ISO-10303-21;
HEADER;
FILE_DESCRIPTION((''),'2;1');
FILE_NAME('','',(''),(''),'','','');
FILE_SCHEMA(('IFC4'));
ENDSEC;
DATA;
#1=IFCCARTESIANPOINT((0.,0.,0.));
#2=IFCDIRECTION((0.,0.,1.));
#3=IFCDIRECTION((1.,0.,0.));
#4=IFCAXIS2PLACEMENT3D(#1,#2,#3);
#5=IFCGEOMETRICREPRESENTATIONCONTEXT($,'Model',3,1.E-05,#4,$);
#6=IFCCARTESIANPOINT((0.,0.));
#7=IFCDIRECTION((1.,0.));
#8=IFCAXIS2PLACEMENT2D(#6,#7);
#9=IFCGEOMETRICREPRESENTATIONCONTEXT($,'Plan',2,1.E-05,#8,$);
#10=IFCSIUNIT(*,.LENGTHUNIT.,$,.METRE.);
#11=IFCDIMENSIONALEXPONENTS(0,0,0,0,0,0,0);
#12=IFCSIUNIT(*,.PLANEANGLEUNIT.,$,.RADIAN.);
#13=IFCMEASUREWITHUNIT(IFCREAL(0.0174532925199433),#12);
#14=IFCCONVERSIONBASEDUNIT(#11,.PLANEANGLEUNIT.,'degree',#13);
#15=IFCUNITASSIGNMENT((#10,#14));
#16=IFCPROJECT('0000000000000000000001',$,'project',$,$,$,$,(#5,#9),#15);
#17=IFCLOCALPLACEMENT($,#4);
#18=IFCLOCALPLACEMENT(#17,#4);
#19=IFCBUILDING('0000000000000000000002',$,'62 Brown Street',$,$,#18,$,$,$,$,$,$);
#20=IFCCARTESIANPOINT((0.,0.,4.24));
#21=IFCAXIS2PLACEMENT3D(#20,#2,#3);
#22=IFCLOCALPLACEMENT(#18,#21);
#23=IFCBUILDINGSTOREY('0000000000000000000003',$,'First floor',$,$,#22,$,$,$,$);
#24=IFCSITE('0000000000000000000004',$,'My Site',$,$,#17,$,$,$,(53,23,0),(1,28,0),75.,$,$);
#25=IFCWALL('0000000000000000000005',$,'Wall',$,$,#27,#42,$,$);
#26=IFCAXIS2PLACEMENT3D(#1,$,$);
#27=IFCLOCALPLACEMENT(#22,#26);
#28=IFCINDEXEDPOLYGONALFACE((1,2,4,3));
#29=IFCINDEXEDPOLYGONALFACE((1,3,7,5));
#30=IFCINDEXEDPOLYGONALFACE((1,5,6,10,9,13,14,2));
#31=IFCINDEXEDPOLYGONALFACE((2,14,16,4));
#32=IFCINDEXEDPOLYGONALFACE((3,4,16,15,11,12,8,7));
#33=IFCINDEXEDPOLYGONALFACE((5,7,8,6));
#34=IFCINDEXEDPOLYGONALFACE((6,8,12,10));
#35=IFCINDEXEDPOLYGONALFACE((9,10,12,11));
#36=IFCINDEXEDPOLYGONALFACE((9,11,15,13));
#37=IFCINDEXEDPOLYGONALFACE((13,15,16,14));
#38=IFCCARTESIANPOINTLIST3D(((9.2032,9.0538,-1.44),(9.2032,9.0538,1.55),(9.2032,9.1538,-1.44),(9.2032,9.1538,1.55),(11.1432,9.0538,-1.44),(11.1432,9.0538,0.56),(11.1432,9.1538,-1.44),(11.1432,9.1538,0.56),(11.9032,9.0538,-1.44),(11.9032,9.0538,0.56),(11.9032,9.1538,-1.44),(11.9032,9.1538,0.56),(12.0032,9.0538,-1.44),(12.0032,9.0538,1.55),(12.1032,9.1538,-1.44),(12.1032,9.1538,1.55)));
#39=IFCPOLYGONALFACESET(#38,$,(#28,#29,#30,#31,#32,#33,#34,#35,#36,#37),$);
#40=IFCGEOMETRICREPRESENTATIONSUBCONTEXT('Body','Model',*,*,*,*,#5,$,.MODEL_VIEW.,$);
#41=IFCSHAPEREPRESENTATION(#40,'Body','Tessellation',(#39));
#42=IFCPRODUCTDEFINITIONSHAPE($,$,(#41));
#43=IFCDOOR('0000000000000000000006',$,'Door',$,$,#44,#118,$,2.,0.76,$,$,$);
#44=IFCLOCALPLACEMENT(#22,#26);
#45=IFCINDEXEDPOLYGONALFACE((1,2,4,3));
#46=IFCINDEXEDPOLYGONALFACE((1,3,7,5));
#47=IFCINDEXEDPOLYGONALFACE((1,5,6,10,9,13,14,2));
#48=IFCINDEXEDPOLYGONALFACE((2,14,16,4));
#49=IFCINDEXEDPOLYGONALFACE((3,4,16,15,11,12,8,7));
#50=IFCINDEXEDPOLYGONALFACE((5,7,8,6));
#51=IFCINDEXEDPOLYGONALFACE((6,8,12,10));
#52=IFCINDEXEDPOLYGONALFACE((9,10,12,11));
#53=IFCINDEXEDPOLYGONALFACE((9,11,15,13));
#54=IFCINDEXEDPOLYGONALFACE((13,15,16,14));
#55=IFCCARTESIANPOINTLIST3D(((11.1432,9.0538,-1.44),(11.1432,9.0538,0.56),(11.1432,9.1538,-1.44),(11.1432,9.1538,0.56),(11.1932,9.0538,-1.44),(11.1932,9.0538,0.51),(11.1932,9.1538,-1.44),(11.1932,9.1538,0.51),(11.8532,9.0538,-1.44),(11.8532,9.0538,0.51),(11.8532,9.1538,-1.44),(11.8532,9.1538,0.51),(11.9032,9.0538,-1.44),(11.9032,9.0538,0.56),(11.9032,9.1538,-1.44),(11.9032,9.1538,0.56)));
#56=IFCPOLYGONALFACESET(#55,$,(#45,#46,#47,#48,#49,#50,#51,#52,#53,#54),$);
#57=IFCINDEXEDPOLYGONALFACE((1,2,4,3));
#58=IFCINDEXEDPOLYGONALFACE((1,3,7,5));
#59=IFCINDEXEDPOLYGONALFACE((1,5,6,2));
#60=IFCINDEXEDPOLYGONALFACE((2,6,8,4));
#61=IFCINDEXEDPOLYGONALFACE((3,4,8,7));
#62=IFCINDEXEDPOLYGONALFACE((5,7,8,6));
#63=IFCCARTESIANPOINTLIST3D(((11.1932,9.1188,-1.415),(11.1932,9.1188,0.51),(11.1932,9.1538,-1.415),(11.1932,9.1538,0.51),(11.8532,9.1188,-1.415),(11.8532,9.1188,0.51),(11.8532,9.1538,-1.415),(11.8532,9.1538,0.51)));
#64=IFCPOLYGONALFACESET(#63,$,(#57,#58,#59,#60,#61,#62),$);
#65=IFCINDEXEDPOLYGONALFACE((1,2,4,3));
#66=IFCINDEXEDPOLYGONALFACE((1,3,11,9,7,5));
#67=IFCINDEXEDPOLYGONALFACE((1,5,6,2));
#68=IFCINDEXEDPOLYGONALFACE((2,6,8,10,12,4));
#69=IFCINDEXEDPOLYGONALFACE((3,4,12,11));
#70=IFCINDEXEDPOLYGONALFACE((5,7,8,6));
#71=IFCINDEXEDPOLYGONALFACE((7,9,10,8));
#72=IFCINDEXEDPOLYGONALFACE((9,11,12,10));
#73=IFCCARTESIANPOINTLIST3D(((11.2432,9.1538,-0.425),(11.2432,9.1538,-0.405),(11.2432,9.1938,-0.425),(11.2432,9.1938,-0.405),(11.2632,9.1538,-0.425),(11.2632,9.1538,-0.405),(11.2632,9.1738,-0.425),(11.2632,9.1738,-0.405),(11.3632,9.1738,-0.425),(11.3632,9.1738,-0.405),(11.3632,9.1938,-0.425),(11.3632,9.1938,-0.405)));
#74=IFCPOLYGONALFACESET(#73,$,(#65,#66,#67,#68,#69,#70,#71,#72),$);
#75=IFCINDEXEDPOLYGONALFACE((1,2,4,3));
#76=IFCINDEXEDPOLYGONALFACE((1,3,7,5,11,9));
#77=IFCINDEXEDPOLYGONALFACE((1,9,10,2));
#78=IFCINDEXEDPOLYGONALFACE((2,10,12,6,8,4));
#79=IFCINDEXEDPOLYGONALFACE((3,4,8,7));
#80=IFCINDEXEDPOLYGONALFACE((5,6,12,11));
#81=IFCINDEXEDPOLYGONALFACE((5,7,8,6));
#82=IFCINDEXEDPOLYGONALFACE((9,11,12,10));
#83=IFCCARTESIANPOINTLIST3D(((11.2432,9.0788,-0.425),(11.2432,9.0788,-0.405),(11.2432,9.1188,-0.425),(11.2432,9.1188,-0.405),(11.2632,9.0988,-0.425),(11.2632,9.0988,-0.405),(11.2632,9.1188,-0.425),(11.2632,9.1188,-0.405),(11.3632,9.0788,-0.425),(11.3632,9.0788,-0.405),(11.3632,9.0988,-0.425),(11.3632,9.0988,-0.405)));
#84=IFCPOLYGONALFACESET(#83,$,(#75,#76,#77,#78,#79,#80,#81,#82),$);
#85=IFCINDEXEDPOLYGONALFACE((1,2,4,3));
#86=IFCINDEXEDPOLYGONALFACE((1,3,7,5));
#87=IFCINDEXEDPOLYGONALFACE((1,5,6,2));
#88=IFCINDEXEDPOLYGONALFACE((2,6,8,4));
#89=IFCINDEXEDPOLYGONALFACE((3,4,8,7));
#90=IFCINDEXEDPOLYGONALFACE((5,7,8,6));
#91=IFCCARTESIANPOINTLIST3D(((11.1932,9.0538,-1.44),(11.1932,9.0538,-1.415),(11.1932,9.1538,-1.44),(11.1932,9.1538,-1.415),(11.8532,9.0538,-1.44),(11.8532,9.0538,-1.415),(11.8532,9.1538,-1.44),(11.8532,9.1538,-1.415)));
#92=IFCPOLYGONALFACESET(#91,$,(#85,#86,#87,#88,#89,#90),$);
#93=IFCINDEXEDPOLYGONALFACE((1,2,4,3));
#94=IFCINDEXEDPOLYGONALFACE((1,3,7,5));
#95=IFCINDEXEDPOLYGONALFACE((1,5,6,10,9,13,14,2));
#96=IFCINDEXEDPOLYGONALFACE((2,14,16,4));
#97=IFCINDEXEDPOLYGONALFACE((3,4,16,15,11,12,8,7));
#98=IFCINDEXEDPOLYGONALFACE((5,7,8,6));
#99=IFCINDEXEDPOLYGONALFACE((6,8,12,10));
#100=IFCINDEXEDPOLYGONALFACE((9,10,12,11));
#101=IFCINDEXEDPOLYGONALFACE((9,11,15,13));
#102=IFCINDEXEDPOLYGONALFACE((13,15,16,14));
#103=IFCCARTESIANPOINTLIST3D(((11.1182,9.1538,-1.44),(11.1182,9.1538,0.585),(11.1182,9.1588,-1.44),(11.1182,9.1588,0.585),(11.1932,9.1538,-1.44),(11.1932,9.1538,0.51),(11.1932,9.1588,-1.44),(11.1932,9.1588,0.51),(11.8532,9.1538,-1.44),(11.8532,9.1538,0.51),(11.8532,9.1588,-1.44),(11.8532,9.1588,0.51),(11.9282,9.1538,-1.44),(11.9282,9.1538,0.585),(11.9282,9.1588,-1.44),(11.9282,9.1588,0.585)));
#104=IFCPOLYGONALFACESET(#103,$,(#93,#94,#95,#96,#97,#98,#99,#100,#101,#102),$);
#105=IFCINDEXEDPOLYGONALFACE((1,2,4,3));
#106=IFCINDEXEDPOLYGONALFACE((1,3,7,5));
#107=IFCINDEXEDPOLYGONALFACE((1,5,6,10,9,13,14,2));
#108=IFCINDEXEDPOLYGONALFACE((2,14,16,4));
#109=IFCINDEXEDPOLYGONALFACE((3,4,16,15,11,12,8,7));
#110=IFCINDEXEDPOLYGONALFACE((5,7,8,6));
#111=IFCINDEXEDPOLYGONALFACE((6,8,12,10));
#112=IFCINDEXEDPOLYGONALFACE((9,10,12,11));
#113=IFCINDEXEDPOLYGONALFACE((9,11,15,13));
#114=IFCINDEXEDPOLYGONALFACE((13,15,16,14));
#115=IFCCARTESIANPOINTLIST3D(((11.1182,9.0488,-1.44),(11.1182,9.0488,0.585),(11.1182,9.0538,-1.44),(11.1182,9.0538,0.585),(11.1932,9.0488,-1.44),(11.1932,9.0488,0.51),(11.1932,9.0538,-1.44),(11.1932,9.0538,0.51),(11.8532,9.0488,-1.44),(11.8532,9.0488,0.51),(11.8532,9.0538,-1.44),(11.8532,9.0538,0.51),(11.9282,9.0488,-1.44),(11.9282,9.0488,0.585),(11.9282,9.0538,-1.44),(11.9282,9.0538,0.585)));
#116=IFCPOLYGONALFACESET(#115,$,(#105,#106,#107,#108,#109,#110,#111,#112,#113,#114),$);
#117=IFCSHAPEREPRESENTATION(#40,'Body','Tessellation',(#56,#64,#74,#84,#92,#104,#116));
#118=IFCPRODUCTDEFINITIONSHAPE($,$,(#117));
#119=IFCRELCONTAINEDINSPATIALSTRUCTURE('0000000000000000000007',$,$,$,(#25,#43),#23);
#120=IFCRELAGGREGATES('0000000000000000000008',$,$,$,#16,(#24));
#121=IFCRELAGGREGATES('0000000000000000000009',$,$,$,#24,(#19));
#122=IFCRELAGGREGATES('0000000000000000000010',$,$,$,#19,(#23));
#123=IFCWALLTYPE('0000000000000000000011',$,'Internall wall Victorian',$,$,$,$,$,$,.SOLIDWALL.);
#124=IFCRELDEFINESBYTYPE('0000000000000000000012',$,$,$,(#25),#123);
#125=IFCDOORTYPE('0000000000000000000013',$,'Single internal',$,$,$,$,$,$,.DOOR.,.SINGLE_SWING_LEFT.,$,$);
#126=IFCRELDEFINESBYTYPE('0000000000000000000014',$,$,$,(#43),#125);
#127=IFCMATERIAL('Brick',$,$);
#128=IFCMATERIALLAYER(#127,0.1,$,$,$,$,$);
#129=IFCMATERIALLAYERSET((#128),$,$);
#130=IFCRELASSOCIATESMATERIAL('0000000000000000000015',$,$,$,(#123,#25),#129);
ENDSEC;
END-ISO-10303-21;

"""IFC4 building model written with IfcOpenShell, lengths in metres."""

from ifc_helpers import new_model, entity, si_unit, converted_unit, frame, origin_with_axes, origin_2d_with_axis, place, context, subcontext, project, spatial, line, indexed_curve, outline, extrude, clip, halfspace, shape, source, transform, mapped, material, layer, layer_set, layer_usage, type_object, type_shapes, element, fill, save


model = new_model("IFC4")

# Units and contexts
model_context = context("Model", 3, precision=1e-05, world=origin_with_axes())
plan_context = context("Plan", 2, precision=1e-05, world=origin_2d_with_axis())
body_context_1 = subcontext(model_context, "Body", "Model", "MODEL_VIEW")
body_context_2 = subcontext(plan_context, "Body", "Plan", "PLAN_VIEW")
ifc_project = project(units=[si_unit("LENGTHUNIT", "METRE"), converted_unit("PLANEANGLEUNIT", "degree", entity("IfcReal", 0.0174532925199433), si_unit("PLANEANGLEUNIT", "RADIAN"), dimensions=[0, 0, 0, 0, 0, 0, 0])], contexts=[model_context, plan_context])

# Site, building, storey
site_placement = place(None, origin_with_axes())
site = spatial("IfcSite", under=ifc_project, at=site_placement, Name="My Site", RefLatitude=(53, 23, 0), RefLongitude=(1, 28, 0), RefElevation=75.0)
building_placement = place(site_placement, origin_with_axes())
building = spatial("IfcBuilding", under=site, at=building_placement, Name="62 Brown Street")
storey_placement = place(building_placement, frame((0.0, 0.0, 4.24), z_axis=(0.0, 0.0, 1.0), x_axis=(1.0, 0.0, 0.0)))
storey = spatial("IfcBuildingStorey", under=building, at=storey_placement, Name="First floor")

# Shared definitions
ifc_material_1 = material(Name="Brick")
ifc_layer_1 = layer(ifc_material_1, 0.1)
ifc_layer_set_1 = layer_set([ifc_layer_1])
wall_type_1 = type_object("IfcWallType", Name="Internall wall Victorian", PredefinedType="SOLIDWALL", material=ifc_layer_set_1)

# Wall, opening, door
ifc_layer_usage_1 = layer_usage(ifc_layer_set_1, "AXIS2", "POSITIVE", 0.0)
wall_1_placement = place(storey_placement, frame((12.1032, 9.1538, -1.44), z_axis=(0.0, 0.0, 1.0), x_axis=(-1.0, 0.0, 0.0)))
wall_1 = element("IfcWall", 1, at=wall_1_placement, inside=storey, type_object=wall_type_1, material=ifc_layer_usage_1, Name="Wall", context=body_context_1, shape_type="Clipping", body=[
    clip(extrude(outline(indexed_curve([(0.0, 0.0), (0.0, 0.1), (2.9, 0.1), (2.9, 0.0), (0.0, 0.0)], self_intersect=False)), origin_with_axes(), (0.0, 0.0, 1.0), 2.99), halfspace(frame((0.0, 0.0, -2.8), z_axis=(-0.299001, 0.299001, 0.0), x_axis=(0.1, 0.1, 0.0)), False)),
])
shared_shape_1 = source(origin_with_axes(), body_context_1, "Body", "SweptSolid", [
    extrude(outline(indexed_curve([(0.0, 0.0), (0.76, 0.0), (0.76, 2.0), (0.0, 2.0)], segments=[line(1, 2, 3, 4, 1)])), frame((0.0, -0.6, 0.0), z_axis=(0.0, -1.0, 0.0), x_axis=(1.0, 0.0, 0.0)), (0.0, 0.0, -1.0), 1.2),
])
opening_placement = place(wall_1_placement, frame((0.2, 0.0, 0.0), z_axis=(0.0, 0.0, 1.0), x_axis=(1.0, 0.0, 0.0)))
opening = element("IfcOpeningElement", 2, at=opening_placement, cuts=wall_1, PredefinedType="OPENING", context=body_context_1, shape_type="MappedRepresentation", body=[
    mapped(shared_shape_1, transform((0.0, 0.0, 0.0), x_axis=(1.0, 0.0, 0.0), y_axis=(0.0, 1.0, 0.0), z_axis=(0.0, 0.0, 1.0), scale=1.0)),
])
door_type = type_object("IfcDoorType", Name="Single internal", OperationType="SINGLE_SWING_LEFT", PredefinedType="DOOR")
shared_shape_2 = source(origin_with_axes(), body_context_1, "Body", "SweptSolid", [
    extrude(outline(indexed_curve([(0.0, 0.0), (0.0, 2.0), (0.76, 2.0), (0.76, 0.0), (0.71, 0.0), (0.71, 1.95), (0.05, 1.95), (0.05, 0.0)], segments=[line(1, 2, 3, 4, 5, 6, 7, 8, 1)])), frame((0.0, 0.0, 0.0), z_axis=(0.0, -1.0, 0.0), x_axis=(1.0, 0.0, 0.0)), (0.0, 0.0, -1.0), 0.1),
    extrude(outline(indexed_curve([(0.0, 0.0), (0.66, 0.0), (0.66, 0.035), (0.0, 0.035)], segments=[line(1, 2, 3, 4, 1)])), frame((0.05, 0.0, 0.025), z_axis=(0.0, 0.0, 1.0), x_axis=(1.0, 0.0, 0.0)), (0.0, 0.0, 1.0), 1.925),
    extrude(outline(indexed_curve([(0.0, 0.0), (0.0, -0.04), (-0.12, -0.04), (-0.12, -0.02), (-0.02, -0.02), (-0.02, 0.0)], segments=[line(1, 2, 3, 4, 5, 6, 1)])), frame((0.66, 0.0, 1.015), z_axis=(0.0, 0.0, 1.0), x_axis=(1.0, 0.0, 0.0)), (0.0, 0.0, 1.0), 0.02),
    extrude(outline(indexed_curve([(0.0, 0.0), (0.0, 0.04), (-0.12, 0.04), (-0.12, 0.02), (-0.02, 0.02), (-0.02, 0.0)], segments=[line(1, 2, 3, 4, 5, 6, 1)])), frame((0.66, 0.035, 1.015), z_axis=(0.0, 0.0, 1.0), x_axis=(1.0, 0.0, 0.0)), (0.0, 0.0, 1.0), 0.02),
    extrude(outline(indexed_curve([(0.0, 0.0), (0.66, 0.0), (0.66, 0.1), (0.0, 0.1)], segments=[line(1, 2, 3, 4, 1)])), frame((0.05, 0.0, 0.0), z_axis=(0.0, 0.0, 1.0), x_axis=(1.0, 0.0, 0.0)), (0.0, 0.0, 1.0), 0.025),
    extrude(outline(indexed_curve([(0.0, 0.0), (0.0, 2.025), (0.81, 2.025), (0.81, 0.0), (0.735, 0.0), (0.735, 1.95), (0.075, 1.95), (0.075, 0.0)], segments=[line(1, 2, 3, 4, 5, 6, 7, 8, 1)])), frame((-0.025, -0.005, 0.0), z_axis=(0.0, -1.0, 0.0), x_axis=(1.0, 0.0, 0.0)), (0.0, 0.0, -1.0), 0.005),
    extrude(outline(indexed_curve([(0.0, 0.0), (0.0, 2.025), (0.81, 2.025), (0.81, 0.0), (0.735, 0.0), (0.735, 1.95), (0.075, 1.95), (0.075, 0.0)], segments=[line(1, 2, 3, 4, 5, 6, 7, 8, 1)])), frame((-0.025, 0.1, 0.0), z_axis=(0.0, -1.0, 0.0), x_axis=(1.0, 0.0, 0.0)), (0.0, 0.0, -1.0), 0.005),
])
shared_shape_3 = source(origin_with_axes(), body_context_2, "Body", "Curve2D", [
    entity("IfcIndexedPolyCurve", entity("IfcCartesianPointList2D", [[0.0, 0.0], [0.05, 0.0], [0.05, 0.1], [0.0, 0.1]]), [entity("IfcLineIndex", [1, 2, 3, 4, 1])]),
    entity("IfcIndexedPolyCurve", entity("IfcCartesianPointList2D", [[0.76, 0.0], [0.71, 0.0], [0.71, 0.1], [0.76, 0.1]]), [entity("IfcLineIndex", [1, 2, 3, 4, 1])]),
    entity("IfcTrimmedCurve", entity("IfcEllipse", entity("IfcAxis2Placement2D", entity("IfcCartesianPoint", [0.085, 0.1]), entity("IfcDirection", [1.0, 0.0])), 0.625, 0.66), [entity("IfcCartesianPoint", [0.71, 0.1])], [entity("IfcCartesianPoint", [0.085, 0.76])], True, "CARTESIAN"),
    entity("IfcIndexedPolyCurve", entity("IfcCartesianPointList2D", [[0.05, 0.1], [0.085, 0.1], [0.085, 0.76], [0.05, 0.76]]), [entity("IfcLineIndex", [1, 2, 3, 4, 1])]),
])
type_shapes(door_type, [shared_shape_2, shared_shape_3])
door_placement = place(opening_placement, frame((0.0, 0.0, 0.0), z_axis=(0.0, 0.0, 1.0), x_axis=(1.0, 0.0, 0.0)))
door = element("IfcDoor", 3, at=door_placement, inside=storey, type_object=door_type, Name="Door", OverallHeight=2.0, OverallWidth=0.76, shapes=[
    shape(body_context_1, "Body", "MappedRepresentation", [mapped(shared_shape_2, transform((0.0, 0.0, 0.0), x_axis=(1.0, 0.0, 0.0), y_axis=(0.0, 1.0, 0.0), z_axis=(0.0, 0.0, 1.0), scale=1.0))]),
    shape(body_context_2, "Body", "MappedRepresentation", [mapped(shared_shape_3, transform((0.0, 0.0, 0.0), x_axis=(1.0, 0.0, 0.0), y_axis=(0.0, 1.0, 0.0), z_axis=(0.0, 0.0, 1.0), scale=1.0))]),
])
fill(opening, door)

save(model, "model.ifc")
